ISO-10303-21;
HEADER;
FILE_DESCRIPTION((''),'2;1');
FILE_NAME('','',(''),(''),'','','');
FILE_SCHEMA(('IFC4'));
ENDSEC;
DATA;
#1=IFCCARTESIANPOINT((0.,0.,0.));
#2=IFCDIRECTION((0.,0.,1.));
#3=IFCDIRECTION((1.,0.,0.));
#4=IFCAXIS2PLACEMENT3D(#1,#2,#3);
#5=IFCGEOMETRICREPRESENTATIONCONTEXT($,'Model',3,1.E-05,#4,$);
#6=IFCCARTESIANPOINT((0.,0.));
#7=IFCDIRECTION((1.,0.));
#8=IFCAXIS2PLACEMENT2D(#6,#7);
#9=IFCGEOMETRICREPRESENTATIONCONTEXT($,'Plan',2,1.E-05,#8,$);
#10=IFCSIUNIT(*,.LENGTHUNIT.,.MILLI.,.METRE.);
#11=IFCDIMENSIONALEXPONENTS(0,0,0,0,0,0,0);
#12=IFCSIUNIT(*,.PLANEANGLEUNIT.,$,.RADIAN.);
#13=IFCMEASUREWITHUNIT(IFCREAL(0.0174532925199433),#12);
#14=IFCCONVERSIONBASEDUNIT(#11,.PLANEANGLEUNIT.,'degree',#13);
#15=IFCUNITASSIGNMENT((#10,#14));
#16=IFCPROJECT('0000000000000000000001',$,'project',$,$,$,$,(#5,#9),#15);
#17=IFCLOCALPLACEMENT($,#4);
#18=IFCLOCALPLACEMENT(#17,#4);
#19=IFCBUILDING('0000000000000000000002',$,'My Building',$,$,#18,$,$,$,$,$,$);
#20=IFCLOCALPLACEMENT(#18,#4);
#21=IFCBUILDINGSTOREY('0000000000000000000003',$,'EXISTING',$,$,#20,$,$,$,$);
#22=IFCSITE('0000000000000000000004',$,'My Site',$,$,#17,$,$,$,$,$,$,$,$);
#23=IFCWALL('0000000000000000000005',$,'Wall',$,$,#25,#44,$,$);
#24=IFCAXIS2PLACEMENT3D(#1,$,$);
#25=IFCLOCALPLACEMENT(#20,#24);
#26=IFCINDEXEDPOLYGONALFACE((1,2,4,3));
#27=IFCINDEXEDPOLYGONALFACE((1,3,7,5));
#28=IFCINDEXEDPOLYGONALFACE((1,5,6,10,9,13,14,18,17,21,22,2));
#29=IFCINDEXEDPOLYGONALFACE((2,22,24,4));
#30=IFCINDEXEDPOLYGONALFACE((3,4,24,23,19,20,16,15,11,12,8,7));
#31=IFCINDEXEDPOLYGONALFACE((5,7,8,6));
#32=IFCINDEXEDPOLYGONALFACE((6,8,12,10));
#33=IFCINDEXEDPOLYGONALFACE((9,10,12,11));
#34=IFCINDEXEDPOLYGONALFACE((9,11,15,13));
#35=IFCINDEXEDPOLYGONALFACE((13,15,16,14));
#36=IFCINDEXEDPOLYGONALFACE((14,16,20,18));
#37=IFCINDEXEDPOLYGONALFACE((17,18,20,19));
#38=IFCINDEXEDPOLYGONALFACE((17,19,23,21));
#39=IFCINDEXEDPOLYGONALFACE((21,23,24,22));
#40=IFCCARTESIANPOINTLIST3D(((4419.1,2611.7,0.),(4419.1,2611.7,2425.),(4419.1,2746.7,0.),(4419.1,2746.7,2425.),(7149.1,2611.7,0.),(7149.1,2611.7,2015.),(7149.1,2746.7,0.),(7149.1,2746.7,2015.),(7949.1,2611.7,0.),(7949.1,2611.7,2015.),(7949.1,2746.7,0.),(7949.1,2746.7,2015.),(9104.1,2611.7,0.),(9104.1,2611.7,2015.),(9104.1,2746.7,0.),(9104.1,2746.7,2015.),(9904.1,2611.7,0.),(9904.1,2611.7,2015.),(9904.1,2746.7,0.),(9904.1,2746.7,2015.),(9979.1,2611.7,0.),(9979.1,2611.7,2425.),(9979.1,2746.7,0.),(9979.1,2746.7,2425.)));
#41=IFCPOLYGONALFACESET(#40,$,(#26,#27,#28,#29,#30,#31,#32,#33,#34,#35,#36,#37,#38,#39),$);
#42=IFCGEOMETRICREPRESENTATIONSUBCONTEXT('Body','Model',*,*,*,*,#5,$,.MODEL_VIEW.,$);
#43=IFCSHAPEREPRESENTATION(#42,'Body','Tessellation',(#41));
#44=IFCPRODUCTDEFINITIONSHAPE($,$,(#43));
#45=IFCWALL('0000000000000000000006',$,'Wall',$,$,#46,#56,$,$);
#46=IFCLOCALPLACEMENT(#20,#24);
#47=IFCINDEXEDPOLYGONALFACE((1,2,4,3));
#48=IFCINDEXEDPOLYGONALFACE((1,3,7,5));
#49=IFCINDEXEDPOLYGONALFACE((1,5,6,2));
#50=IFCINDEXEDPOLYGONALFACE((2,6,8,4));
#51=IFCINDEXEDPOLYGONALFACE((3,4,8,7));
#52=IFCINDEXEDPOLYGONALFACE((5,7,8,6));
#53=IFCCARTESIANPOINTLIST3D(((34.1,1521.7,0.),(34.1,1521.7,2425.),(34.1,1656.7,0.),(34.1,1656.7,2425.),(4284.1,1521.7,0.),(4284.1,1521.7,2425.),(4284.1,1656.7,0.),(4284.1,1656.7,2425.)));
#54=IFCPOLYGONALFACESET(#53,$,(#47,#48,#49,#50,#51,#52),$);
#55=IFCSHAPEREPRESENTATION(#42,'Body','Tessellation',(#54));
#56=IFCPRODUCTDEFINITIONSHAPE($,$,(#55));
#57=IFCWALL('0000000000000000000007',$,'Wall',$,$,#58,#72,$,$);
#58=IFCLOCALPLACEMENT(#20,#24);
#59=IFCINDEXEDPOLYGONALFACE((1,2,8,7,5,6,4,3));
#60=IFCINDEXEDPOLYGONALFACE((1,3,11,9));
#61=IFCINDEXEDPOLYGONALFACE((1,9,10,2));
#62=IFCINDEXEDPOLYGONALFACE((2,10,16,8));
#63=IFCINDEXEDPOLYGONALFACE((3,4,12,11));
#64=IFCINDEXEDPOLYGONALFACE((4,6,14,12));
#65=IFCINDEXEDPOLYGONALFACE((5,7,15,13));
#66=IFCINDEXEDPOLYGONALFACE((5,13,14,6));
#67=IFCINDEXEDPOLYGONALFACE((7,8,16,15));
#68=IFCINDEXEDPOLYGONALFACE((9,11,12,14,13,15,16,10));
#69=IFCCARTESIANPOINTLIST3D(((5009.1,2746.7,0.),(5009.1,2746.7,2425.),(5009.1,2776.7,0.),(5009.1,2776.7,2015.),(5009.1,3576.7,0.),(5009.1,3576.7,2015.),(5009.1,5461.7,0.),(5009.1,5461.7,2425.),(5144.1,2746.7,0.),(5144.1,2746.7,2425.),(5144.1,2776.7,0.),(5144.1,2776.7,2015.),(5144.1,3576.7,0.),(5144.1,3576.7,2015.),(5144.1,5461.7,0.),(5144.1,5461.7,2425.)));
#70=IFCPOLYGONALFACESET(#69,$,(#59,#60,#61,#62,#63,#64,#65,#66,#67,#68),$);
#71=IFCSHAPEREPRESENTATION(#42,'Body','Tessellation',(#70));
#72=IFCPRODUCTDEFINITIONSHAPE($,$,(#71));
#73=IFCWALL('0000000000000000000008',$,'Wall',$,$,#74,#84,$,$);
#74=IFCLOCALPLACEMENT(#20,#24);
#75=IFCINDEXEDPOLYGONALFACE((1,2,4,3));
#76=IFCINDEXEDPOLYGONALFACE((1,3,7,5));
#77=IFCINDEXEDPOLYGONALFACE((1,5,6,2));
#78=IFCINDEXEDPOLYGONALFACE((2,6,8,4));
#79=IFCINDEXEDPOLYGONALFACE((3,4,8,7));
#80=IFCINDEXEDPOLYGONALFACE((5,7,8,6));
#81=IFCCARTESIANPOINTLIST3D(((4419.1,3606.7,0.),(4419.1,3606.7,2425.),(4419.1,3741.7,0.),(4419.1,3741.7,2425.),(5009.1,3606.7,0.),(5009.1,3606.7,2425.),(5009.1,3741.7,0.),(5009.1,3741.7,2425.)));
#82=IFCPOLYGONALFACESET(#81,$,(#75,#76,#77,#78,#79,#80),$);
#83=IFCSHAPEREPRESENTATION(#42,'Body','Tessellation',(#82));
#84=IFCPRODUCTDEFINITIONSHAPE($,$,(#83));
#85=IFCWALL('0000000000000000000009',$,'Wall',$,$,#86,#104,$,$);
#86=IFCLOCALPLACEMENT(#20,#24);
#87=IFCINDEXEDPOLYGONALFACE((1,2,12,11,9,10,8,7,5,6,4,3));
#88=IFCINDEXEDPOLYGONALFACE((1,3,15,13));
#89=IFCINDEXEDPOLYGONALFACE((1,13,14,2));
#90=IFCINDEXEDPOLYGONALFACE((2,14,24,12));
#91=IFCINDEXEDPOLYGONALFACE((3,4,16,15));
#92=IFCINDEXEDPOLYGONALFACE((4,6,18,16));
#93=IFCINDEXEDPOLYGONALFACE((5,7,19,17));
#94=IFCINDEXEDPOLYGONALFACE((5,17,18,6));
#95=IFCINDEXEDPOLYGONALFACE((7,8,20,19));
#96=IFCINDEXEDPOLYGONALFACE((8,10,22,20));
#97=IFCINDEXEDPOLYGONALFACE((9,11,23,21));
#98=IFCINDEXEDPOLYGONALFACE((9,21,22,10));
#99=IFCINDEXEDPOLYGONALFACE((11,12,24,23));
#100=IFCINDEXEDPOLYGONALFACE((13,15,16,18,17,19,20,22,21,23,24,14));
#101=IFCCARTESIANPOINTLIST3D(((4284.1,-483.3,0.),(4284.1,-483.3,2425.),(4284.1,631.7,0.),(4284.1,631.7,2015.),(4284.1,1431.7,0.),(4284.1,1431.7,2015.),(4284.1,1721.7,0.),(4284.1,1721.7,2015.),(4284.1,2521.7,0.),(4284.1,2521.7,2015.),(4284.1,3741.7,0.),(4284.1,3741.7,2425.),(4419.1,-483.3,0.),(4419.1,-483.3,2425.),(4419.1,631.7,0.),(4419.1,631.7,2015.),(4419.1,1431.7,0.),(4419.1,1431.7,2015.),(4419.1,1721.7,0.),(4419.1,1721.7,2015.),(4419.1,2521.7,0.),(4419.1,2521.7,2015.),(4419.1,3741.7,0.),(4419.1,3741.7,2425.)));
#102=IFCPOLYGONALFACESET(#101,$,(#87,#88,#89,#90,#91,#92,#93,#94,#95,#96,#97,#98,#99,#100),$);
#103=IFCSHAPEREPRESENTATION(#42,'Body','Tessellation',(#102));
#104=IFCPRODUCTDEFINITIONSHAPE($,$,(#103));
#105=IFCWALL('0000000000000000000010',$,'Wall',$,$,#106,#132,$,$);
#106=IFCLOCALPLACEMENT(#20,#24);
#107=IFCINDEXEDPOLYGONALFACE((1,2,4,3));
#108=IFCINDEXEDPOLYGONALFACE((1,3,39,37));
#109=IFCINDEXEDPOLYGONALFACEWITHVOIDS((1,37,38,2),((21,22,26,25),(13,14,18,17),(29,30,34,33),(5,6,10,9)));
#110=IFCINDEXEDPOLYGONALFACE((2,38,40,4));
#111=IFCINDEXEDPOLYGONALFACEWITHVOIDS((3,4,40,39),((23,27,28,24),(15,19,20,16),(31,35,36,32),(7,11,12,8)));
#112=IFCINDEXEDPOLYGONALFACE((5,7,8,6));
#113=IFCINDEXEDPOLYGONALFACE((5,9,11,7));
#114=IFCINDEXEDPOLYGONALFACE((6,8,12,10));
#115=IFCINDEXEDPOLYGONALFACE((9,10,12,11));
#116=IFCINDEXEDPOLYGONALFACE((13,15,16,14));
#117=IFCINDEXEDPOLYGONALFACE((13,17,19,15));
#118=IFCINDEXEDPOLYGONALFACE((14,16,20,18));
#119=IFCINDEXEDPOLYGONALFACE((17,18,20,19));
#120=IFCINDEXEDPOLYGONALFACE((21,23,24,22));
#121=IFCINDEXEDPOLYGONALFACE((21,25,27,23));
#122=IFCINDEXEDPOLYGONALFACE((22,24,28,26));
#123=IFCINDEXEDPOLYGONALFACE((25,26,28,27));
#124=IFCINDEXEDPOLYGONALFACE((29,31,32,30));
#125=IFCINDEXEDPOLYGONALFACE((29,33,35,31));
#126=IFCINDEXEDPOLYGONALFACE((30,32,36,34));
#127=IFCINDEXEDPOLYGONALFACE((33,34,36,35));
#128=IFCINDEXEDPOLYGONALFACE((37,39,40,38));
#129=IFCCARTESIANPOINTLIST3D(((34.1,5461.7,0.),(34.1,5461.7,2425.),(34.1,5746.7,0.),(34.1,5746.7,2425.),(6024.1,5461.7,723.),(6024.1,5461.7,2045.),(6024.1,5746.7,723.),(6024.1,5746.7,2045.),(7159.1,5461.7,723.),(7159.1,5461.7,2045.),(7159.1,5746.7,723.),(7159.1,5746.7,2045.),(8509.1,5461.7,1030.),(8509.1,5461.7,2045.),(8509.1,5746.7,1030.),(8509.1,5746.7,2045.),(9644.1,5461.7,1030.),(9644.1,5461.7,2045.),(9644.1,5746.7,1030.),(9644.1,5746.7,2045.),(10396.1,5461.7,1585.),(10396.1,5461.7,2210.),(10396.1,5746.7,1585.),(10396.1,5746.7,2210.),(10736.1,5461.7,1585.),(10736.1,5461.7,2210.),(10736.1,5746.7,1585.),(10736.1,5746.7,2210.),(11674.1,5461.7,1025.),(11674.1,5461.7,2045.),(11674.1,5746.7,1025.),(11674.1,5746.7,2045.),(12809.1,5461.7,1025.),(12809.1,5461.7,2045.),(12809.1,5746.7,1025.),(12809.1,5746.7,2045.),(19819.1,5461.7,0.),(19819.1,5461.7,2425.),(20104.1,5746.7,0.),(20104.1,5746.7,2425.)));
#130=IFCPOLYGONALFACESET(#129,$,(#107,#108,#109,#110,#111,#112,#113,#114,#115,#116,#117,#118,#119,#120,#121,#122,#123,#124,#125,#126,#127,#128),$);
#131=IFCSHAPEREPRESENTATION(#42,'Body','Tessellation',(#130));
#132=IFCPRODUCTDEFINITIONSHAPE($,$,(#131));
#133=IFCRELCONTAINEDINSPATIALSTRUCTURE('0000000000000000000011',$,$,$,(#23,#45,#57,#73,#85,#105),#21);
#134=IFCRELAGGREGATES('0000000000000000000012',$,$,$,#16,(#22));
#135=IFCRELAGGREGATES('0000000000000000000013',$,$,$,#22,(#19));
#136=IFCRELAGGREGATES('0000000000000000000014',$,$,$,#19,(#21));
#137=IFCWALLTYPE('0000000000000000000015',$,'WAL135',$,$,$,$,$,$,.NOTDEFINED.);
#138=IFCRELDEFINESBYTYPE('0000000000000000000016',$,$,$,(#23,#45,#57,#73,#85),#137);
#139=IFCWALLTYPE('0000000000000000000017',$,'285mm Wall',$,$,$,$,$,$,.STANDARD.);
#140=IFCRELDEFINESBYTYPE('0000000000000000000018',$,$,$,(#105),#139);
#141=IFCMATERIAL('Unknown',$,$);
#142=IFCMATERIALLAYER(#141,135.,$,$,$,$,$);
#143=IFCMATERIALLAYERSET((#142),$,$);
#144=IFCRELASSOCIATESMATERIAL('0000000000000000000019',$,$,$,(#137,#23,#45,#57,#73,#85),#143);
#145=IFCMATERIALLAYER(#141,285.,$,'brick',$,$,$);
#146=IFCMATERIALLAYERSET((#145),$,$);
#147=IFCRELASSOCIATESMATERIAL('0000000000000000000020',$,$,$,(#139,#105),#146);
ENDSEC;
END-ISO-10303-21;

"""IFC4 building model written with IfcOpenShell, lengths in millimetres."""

from ifc_helpers import new_model, entity, si_unit, converted_unit, frame, origin_with_axes, origin_2d_with_axis, place, context, subcontext, project, spatial, line, indexed_curve, outline, extrude, clip, halfspace, source, transform, mapped, material, layer, layer_set, layer_usage, type_object, element, save


model = new_model("IFC4")

# Units and contexts
model_context = context("Model", 3, precision=1e-05, world=origin_with_axes())
plan_context = context("Plan", 2, precision=1e-05, world=origin_2d_with_axis())
body_context = subcontext(model_context, "Body", "Model", "MODEL_VIEW")
ifc_project = project(units=[si_unit("LENGTHUNIT", "METRE", prefix="MILLI"), converted_unit("PLANEANGLEUNIT", "degree", entity("IfcReal", 0.0174532925199433), si_unit("PLANEANGLEUNIT", "RADIAN"), dimensions=[0, 0, 0, 0, 0, 0, 0])], contexts=[model_context, plan_context])

# Site, building, storey
site_placement = place(None, origin_with_axes())
site = spatial("IfcSite", under=ifc_project, at=site_placement, Name="My Site")
building_placement = place(site_placement, origin_with_axes())
building = spatial("IfcBuilding", under=site, at=building_placement, Name="My Building")
storey_placement = place(building_placement, origin_with_axes())
storey = spatial("IfcBuildingStorey", under=building, at=storey_placement, Name="EXISTING")

# Shared definitions
ifc_material = material(Name="Unknown")

# Wall, openings
ifc_layer_1 = layer(ifc_material, 135.0)
ifc_layer_set_1 = layer_set([ifc_layer_1])
ifc_layer_usage_1 = layer_usage(ifc_layer_set_1, "AXIS2", "POSITIVE", 0.0)
wall_type_1 = type_object("IfcWallType", Name="WAL135", PredefinedType="NOTDEFINED", material=ifc_layer_set_1)
wall_1_placement = place(storey_placement, frame((4419.1, 2611.7, 0.0), z_axis=(0.0, 0.0, 1.0), x_axis=(1.0, 0.0, 0.0)))
wall_1 = element("IfcWall", 1, at=wall_1_placement, inside=storey, type_object=wall_type_1, material=ifc_layer_usage_1, Name="Wall", context=body_context, shape_type="SweptSolid", body=[
    extrude(outline(indexed_curve([(0.0, 0.0), (0.0, 135.0), (5560.0, 135.0), (5560.0, 0.0), (0.0, 0.0)], self_intersect=False)), origin_with_axes(), (0.0, 0.0, 1.0), 2425.0),
])
shared_shape_1 = source(origin_with_axes(), body_context, "Body", "SweptSolid", [
    extrude(outline(indexed_curve([(0.0, 0.0), (800.0, 0.0), (800.0, 2015.0), (0.0, 2015.0)], segments=[line(1, 2, 3, 4, 1)])), frame((0.0, -600.0, 0.0), z_axis=(0.0, -1.0, 0.0), x_axis=(1.0, 0.0, 0.0)), (0.0, 0.0, -1.0), 1200.0),
])
opening_1_placement = place(wall_1_placement, frame((4685.0, 53.7, 0.0), z_axis=(0.0, 0.0, 1.0), x_axis=(1.0, 0.0, 0.0)))
element("IfcOpeningElement", 2, at=opening_1_placement, cuts=wall_1, PredefinedType="OPENING", context=body_context, shape_type="MappedRepresentation", body=[
    mapped(shared_shape_1, transform((0.0, 0.0, 0.0), x_axis=(1.0, 0.0, 0.0), y_axis=(0.0, 1.0, 0.0), z_axis=(0.0, 0.0, 1.0), scale=1.0)),
])
opening_2_placement = place(wall_1_placement, frame((2730.0, 0.0, 0.0), z_axis=(0.0, 0.0, 1.0), x_axis=(1.0, 0.0, 0.0)))
element("IfcOpeningElement", 3, at=opening_2_placement, cuts=wall_1, PredefinedType="OPENING", context=body_context, shape_type="MappedRepresentation", body=[
    mapped(shared_shape_1, transform((0.0, 0.0, 0.0), x_axis=(1.0, 0.0, 0.0), y_axis=(0.0, 1.0, 0.0), z_axis=(0.0, 0.0, 1.0), scale=1.0)),
])

# Wall
ifc_layer_usage_2 = layer_usage(ifc_layer_set_1, "AXIS2", "POSITIVE", 0.0)
wall_2_placement = place(storey_placement, frame((34.1, 1521.7, 0.0), z_axis=(0.0, 0.0, 1.0), x_axis=(1.0, 0.0, 0.0)))
element("IfcWall", 4, at=wall_2_placement, inside=storey, type_object=wall_type_1, material=ifc_layer_usage_2, Name="Wall", context=body_context, shape_type="SweptSolid", body=[
    extrude(outline(indexed_curve([(0.0, 0.0), (0.0, 135.0), (4250.0, 135.0), (4250.0, 0.0), (0.0, 0.0)], self_intersect=False)), origin_with_axes(), (0.0, 0.0, 1.0), 2425.0),
])

# Wall, opening
ifc_layer_usage_3 = layer_usage(ifc_layer_set_1, "AXIS2", "POSITIVE", 0.0)
wall_3_placement = place(storey_placement, frame((5009.1, 5461.7, 0.0), z_axis=(0.0, 0.0, 1.0), x_axis=(0.0, -1.0, 0.0)))
wall_3 = element("IfcWall", 5, at=wall_3_placement, inside=storey, type_object=wall_type_1, material=ifc_layer_usage_3, Name="Wall", context=body_context, shape_type="SweptSolid", body=[
    extrude(outline(indexed_curve([(0.0, 0.0), (0.0, 135.0), (2715.0, 135.0), (2715.0, 0.0), (0.0, 0.0)], self_intersect=False)), origin_with_axes(), (0.0, 0.0, 1.0), 2425.0),
])
opening_3_placement = place(wall_3_placement, frame((1885.0, 0.0, 0.0), z_axis=(0.0, 0.0, 1.0), x_axis=(1.0, 0.0, 0.0)))
element("IfcOpeningElement", 6, at=opening_3_placement, cuts=wall_3, PredefinedType="OPENING", context=body_context, shape_type="MappedRepresentation", body=[
    mapped(shared_shape_1, transform((0.0, 0.0, 0.0), x_axis=(1.0, 0.0, 0.0), y_axis=(0.0, 1.0, 0.0), z_axis=(0.0, 0.0, 1.0), scale=1.0)),
])

# Wall
ifc_layer_usage_4 = layer_usage(ifc_layer_set_1, "AXIS2", "POSITIVE", 0.0)
wall_4_placement = place(storey_placement, frame((4419.1, 3606.7, 0.0), z_axis=(0.0, 0.0, 1.0), x_axis=(1.0, 0.0, 0.0)))
element("IfcWall", 7, at=wall_4_placement, inside=storey, type_object=wall_type_1, material=ifc_layer_usage_4, Name="Wall", context=body_context, shape_type="SweptSolid", body=[
    extrude(outline(indexed_curve([(0.0, 0.0), (0.0, 135.0), (590.0, 135.0), (590.0, 0.0), (0.0, 0.0)], self_intersect=False)), origin_with_axes(), (0.0, 0.0, 1.0), 2425.0),
])

# Walls, openings
ifc_layer_usage_5 = layer_usage(ifc_layer_set_1, "AXIS2", "POSITIVE", 0.0)
wall_5_placement = place(storey_placement, frame((4284.1, 3741.7, 0.0), z_axis=(0.0, 0.0, 1.0), x_axis=(0.0, -1.0, 0.0)))
wall_5 = element("IfcWall", 8, at=wall_5_placement, inside=storey, type_object=wall_type_1, material=ifc_layer_usage_5, Name="Wall", context=body_context, shape_type="SweptSolid", body=[
    extrude(outline(indexed_curve([(0.0, 0.0), (0.0, 135.0), (4225.0, 135.0), (4225.0, 0.0), (0.0, 0.0)], self_intersect=False)), origin_with_axes(), (0.0, 0.0, 1.0), 2425.0),
])
opening_4_placement = place(wall_5_placement, frame((1220.0, 0.0, 0.0), z_axis=(0.0, 0.0, 1.0), x_axis=(1.0, 0.0, 0.0)))
element("IfcOpeningElement", 9, at=opening_4_placement, cuts=wall_5, PredefinedType="OPENING", context=body_context, shape_type="MappedRepresentation", body=[
    mapped(shared_shape_1, transform((0.0, 0.0, 0.0), x_axis=(1.0, 0.0, 0.0), y_axis=(0.0, 1.0, 0.0), z_axis=(0.0, 0.0, 1.0), scale=1.0)),
])
opening_5_placement = place(wall_5_placement, frame((2310.0, 0.0, 0.0), z_axis=(0.0, 0.0, 1.0), x_axis=(1.0, 0.0, 0.0)))
element("IfcOpeningElement", 10, at=opening_5_placement, cuts=wall_5, PredefinedType="OPENING", context=body_context, shape_type="MappedRepresentation", body=[
    mapped(shared_shape_1, transform((0.0, 0.0, 0.0), x_axis=(1.0, 0.0, 0.0), y_axis=(0.0, 1.0, 0.0), z_axis=(0.0, 0.0, 1.0), scale=1.0)),
])
ifc_layer_2 = layer(ifc_material, 285.0, Name="brick")
ifc_layer_set_2 = layer_set([ifc_layer_2])
ifc_layer_usage_6 = layer_usage(ifc_layer_set_2, "AXIS2", "POSITIVE", 0.0)
wall_type_2 = type_object("IfcWallType", Name="285mm Wall", PredefinedType="STANDARD", material=ifc_layer_set_2)
wall_6_placement = place(storey_placement, frame((34.1, 5461.7, 0.0), z_axis=(0.0, 0.0, 1.0), x_axis=(1.0, 0.0, 0.0)))
wall_6 = element("IfcWall", 11, at=wall_6_placement, inside=storey, type_object=wall_type_2, material=ifc_layer_usage_6, Name="Wall", context=body_context, shape_type="Clipping", body=[
    clip(extrude(outline(indexed_curve([(0.0, 0.0), (0.0, 285.0), (20070.0, 285.0), (20070.0, 0.0), (0.0, 0.0)], self_intersect=False)), origin_with_axes(), (0.0, 0.0, 1.0), 2425.0), halfspace(frame((19785.0, 0.0, 0.0), z_axis=(0.707107, -0.707107, 0.0), x_axis=(-0.707107, -0.707107, 0.0)), False)),
])
shared_shape_2 = source(origin_with_axes(), body_context, "Body", "SweptSolid", [
    extrude(outline(indexed_curve([(0.0, 0.0), (340.0, 0.0), (340.0, 625.0), (0.0, 625.0)], segments=[line(1, 2, 3, 4, 1)])), frame((0.0, -600.0, 0.0), z_axis=(0.0, -1.0, 0.0), x_axis=(1.0, 0.0, 0.0)), (0.0, 0.0, -1.0), 1200.0),
])
opening_6_placement = place(wall_6_placement, frame((10362.0, 138.1, 1585.0), z_axis=(0.0, 0.0, 1.0), x_axis=(1.0, 0.0, 0.0)))
element("IfcOpeningElement", 12, at=opening_6_placement, cuts=wall_6, PredefinedType="OPENING", context=body_context, shape_type="MappedRepresentation", body=[
    mapped(shared_shape_2, transform((0.0, 0.0, 0.0), x_axis=(1.0, 0.0, 0.0), y_axis=(0.0, 1.0, 0.0), z_axis=(0.0, 0.0, 1.0), scale=1.0)),
])
shared_shape_3 = source(origin_with_axes(), body_context, "Body", "SweptSolid", [
    extrude(outline(indexed_curve([(0.0, 0.0), (1135.0, 0.0), (1135.0, 1015.0), (0.0, 1015.0)], segments=[line(1, 2, 3, 4, 1)])), frame((0.0, -600.0, 0.0), z_axis=(0.0, -1.0, 0.0), x_axis=(1.0, 0.0, 0.0)), (0.0, 0.0, -1.0), 1200.0),
])
opening_7_placement = place(wall_6_placement, frame((8475.0, 142.1, 1030.0), z_axis=(0.0, 0.0, 1.0), x_axis=(1.0, 0.0, 0.0)))
element("IfcOpeningElement", 13, at=opening_7_placement, cuts=wall_6, PredefinedType="OPENING", context=body_context, shape_type="MappedRepresentation", body=[
    mapped(shared_shape_3, transform((0.0, 0.0, 0.0), x_axis=(1.0, 0.0, 0.0), y_axis=(0.0, 1.0, 0.0), z_axis=(0.0, 0.0, 1.0), scale=1.0)),
])
shared_shape_4 = source(origin_with_axes(), body_context, "Body", "SweptSolid", [
    extrude(outline(indexed_curve([(0.0, 0.0), (1135.0, 0.0), (1135.0, 1322.0), (0.0, 1322.0)], segments=[line(1, 2, 3, 4, 1)])), frame((0.0, -600.0, 0.0), z_axis=(0.0, -1.0, 0.0), x_axis=(1.0, 0.0, 0.0)), (0.0, 0.0, -1.0), 1200.0),
])
opening_8_placement = place(wall_6_placement, frame((5990.0, 100.0, 723.0), z_axis=(0.0, 0.0, 1.0), x_axis=(1.0, 0.0, 0.0)))
element("IfcOpeningElement", 14, at=opening_8_placement, cuts=wall_6, PredefinedType="OPENING", context=body_context, shape_type="MappedRepresentation", body=[
    mapped(shared_shape_4, transform((0.0, 0.0, 0.0), x_axis=(1.0, 0.0, 0.0), y_axis=(0.0, 1.0, 0.0), z_axis=(0.0, 0.0, 1.0), scale=1.0)),
])
shared_shape_5 = source(origin_with_axes(), body_context, "Body", "SweptSolid", [
    extrude(outline(indexed_curve([(0.0, 0.0), (1135.0, 0.0), (1135.0, 1020.0), (0.0, 1020.0)], segments=[line(1, 2, 3, 4, 1)])), frame((0.0, -600.0, 0.0), z_axis=(0.0, -1.0, 0.0), x_axis=(1.0, 0.0, 0.0)), (0.0, 0.0, -1.0), 1200.0),
])
opening_9_placement = place(wall_6_placement, frame((11640.0, 140.3, 1025.0), z_axis=(0.0, 0.0, 1.0), x_axis=(1.0, 0.0, 0.0)))
element("IfcOpeningElement", 15, at=opening_9_placement, cuts=wall_6, PredefinedType="OPENING", context=body_context, shape_type="MappedRepresentation", body=[
    mapped(shared_shape_5, transform((0.0, 0.0, 0.0), x_axis=(1.0, 0.0, 0.0), y_axis=(0.0, 1.0, 0.0), z_axis=(0.0, 0.0, 1.0), scale=1.0)),
])

save(model, "model.ifc")
